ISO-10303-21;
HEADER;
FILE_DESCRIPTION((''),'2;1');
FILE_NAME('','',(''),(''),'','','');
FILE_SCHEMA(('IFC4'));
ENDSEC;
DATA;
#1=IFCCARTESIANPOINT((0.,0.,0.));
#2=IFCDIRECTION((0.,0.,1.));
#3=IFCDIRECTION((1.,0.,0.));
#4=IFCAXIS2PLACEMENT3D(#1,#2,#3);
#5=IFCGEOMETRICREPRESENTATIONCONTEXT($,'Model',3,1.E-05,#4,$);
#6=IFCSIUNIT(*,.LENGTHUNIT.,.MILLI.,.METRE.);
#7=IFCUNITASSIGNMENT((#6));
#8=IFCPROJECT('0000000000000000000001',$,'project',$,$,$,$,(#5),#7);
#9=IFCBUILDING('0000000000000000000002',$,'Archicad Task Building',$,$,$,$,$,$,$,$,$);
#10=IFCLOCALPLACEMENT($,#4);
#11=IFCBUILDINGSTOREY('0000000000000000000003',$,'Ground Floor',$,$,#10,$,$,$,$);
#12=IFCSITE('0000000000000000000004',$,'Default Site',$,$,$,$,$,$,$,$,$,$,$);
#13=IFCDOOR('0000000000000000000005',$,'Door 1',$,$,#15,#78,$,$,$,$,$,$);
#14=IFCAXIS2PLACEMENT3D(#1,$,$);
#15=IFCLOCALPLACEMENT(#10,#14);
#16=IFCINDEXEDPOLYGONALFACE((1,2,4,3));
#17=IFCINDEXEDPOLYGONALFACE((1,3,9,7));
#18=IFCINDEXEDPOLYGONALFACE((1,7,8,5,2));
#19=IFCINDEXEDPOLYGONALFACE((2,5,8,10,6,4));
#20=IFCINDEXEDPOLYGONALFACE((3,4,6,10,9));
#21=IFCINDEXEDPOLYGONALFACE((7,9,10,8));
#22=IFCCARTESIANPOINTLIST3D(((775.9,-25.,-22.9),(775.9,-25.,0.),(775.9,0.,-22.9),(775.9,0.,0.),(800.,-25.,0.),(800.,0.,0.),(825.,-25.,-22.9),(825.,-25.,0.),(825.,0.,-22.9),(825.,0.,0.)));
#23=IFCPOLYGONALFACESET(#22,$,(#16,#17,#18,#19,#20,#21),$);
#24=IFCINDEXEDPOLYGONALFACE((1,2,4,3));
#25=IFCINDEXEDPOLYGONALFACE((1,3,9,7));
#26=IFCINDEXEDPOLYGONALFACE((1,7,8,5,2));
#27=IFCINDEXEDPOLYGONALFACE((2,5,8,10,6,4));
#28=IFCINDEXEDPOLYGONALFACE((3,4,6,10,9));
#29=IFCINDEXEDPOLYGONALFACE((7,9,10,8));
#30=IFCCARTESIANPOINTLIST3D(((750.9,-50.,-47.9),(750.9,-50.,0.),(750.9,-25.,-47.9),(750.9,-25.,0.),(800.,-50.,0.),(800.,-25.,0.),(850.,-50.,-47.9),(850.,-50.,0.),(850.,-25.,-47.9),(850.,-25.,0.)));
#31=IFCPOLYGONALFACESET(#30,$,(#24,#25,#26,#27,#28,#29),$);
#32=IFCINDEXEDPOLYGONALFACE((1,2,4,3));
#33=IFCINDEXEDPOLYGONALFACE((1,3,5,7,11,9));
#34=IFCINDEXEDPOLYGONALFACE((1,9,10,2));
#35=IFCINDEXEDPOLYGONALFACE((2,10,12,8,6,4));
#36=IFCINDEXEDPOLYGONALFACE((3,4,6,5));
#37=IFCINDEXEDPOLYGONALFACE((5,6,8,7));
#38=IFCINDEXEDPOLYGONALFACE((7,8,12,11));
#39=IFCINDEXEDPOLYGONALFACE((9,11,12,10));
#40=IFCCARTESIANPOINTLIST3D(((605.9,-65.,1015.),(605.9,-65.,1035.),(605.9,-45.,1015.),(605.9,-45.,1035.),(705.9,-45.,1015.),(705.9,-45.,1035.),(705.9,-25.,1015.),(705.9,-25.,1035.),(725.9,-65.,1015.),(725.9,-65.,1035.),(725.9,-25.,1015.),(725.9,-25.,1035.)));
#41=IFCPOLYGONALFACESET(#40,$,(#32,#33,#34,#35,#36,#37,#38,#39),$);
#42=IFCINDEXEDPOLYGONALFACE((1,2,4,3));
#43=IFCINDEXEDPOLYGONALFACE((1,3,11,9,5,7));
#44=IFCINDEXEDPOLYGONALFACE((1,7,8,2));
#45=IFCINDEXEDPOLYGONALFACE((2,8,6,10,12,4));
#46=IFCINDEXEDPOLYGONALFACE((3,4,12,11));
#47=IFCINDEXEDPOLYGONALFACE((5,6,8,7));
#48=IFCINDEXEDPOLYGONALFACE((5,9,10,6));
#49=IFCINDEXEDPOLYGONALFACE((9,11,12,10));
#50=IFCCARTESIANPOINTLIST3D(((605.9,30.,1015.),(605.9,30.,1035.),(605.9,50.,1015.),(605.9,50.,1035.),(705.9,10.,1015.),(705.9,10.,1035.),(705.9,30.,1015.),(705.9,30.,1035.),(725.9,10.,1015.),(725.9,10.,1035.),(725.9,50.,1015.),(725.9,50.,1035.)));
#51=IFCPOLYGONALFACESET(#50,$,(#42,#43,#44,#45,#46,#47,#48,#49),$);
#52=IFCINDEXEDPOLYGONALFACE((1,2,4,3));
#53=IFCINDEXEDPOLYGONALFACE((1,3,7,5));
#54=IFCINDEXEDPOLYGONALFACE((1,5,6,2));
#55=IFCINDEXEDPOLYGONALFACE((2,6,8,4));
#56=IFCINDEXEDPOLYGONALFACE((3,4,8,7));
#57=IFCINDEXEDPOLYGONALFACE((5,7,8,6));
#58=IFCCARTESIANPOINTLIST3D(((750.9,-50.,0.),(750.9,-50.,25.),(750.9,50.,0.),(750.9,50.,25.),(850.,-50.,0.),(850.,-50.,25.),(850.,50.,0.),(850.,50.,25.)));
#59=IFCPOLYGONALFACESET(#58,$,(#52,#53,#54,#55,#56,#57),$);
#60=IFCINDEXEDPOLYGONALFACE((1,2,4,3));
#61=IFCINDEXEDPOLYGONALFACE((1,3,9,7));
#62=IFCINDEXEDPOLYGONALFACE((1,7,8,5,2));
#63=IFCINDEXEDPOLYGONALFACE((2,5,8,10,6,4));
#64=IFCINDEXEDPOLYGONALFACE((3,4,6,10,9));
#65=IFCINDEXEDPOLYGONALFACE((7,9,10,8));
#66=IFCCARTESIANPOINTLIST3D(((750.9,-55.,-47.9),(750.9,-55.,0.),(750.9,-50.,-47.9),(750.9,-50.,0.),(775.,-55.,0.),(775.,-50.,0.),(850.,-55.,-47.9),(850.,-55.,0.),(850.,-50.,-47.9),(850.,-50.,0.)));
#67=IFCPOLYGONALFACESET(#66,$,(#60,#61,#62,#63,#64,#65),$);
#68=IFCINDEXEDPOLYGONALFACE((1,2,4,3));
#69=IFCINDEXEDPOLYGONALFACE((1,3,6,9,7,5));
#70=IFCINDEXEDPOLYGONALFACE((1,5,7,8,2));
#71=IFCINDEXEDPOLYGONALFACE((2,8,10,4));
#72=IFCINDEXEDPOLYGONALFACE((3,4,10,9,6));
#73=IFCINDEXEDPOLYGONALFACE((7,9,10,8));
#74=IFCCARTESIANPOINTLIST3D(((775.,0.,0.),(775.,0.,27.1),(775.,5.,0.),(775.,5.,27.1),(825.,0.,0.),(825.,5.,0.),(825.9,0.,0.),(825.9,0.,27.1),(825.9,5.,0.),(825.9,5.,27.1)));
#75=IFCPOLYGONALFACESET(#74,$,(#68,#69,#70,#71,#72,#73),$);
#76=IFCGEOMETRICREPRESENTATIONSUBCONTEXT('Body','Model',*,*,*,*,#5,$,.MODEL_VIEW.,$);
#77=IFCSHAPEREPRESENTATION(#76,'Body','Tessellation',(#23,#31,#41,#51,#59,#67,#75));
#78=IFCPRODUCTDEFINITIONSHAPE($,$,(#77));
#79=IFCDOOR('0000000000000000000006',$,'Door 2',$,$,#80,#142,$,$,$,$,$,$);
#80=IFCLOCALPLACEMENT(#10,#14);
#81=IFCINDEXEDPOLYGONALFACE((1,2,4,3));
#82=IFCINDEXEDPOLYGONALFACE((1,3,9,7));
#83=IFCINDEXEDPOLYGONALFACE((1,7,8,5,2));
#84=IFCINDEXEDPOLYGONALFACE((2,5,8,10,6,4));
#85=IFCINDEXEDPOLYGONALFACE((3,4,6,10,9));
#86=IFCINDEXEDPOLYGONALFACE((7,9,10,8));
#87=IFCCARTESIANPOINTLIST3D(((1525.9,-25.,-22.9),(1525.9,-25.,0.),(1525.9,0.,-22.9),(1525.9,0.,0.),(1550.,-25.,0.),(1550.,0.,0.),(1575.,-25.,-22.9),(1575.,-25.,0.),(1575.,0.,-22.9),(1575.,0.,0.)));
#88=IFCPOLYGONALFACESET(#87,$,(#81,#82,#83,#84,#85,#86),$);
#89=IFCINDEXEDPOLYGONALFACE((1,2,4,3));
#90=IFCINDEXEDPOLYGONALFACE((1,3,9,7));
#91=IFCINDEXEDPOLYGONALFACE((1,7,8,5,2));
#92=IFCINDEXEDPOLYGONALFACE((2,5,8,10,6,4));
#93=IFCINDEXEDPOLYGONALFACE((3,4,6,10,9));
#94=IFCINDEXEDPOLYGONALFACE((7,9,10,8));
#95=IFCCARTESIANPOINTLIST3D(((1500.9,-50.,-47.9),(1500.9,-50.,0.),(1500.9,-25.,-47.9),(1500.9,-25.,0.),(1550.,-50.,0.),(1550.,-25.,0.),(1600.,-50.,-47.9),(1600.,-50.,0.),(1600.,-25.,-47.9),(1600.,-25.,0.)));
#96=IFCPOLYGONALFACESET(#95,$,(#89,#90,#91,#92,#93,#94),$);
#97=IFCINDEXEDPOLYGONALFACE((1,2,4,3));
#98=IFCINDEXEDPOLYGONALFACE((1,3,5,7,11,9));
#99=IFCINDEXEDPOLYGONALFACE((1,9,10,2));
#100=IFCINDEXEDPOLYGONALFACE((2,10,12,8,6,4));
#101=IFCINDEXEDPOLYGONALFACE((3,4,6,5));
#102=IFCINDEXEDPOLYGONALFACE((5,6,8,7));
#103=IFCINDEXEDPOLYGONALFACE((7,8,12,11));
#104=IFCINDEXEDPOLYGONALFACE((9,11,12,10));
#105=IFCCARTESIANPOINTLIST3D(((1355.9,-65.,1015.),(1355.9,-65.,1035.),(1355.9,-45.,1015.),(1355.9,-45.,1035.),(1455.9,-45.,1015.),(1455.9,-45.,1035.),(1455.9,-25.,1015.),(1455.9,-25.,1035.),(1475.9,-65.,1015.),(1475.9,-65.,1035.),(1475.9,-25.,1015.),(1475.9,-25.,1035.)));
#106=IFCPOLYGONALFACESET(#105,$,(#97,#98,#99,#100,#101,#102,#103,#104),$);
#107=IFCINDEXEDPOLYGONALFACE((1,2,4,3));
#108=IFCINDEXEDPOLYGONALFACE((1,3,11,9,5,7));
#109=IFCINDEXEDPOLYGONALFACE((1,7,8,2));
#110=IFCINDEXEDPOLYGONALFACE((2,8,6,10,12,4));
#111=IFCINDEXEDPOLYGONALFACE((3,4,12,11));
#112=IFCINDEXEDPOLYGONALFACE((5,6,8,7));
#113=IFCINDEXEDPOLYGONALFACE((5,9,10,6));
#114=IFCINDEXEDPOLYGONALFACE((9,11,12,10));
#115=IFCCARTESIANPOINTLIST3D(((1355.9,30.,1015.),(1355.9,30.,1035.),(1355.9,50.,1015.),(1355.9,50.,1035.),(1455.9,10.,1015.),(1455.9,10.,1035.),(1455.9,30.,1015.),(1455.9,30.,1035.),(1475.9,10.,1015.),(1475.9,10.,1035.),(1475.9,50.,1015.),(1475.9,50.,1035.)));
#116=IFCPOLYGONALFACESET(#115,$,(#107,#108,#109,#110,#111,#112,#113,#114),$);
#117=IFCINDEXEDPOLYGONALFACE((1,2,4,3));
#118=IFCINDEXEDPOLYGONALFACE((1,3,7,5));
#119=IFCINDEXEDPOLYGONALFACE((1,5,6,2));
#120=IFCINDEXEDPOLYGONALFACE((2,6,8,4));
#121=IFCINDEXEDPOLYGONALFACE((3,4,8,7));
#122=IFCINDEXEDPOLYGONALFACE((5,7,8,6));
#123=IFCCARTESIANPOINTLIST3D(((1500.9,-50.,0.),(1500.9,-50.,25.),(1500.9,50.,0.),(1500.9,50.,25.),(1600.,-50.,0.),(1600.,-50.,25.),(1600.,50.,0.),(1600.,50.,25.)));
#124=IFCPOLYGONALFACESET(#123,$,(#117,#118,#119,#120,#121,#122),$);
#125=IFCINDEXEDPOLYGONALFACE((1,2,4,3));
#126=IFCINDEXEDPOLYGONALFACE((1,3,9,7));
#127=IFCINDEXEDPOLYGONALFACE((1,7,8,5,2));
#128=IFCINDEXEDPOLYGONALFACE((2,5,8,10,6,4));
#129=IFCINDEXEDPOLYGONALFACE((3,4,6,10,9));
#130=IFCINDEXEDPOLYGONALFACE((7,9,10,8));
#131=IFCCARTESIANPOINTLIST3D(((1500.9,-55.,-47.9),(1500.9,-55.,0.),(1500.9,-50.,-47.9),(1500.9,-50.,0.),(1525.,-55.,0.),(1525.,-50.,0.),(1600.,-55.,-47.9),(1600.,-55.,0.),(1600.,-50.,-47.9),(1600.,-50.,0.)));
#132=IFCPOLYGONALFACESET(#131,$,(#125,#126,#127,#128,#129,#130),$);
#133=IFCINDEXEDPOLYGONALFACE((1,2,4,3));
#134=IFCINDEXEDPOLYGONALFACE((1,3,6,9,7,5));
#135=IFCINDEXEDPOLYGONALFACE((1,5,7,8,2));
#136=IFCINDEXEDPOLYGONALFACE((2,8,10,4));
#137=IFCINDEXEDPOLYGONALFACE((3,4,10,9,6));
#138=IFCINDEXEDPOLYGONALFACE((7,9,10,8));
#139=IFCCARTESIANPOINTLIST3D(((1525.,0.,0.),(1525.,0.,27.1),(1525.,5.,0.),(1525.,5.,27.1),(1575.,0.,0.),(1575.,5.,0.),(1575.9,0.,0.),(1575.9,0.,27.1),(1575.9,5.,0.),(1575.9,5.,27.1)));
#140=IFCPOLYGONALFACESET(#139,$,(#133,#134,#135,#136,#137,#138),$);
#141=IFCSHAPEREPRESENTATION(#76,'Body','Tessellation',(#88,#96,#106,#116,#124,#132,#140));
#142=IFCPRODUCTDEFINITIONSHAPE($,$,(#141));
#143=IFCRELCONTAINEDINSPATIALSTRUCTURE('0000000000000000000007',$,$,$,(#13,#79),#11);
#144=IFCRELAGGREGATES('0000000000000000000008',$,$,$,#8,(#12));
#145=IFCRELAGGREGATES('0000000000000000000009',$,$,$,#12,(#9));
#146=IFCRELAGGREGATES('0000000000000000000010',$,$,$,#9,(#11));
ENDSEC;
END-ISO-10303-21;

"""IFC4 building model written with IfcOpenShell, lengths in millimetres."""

from ifc_helpers import new_model, si_unit, frame, origin_with_axes, place, context, subcontext, project, spatial, line, indexed_curve, outline, extrude, element, save


model = new_model("IFC4")

# Units and contexts
model_context = context("Model", 3, precision=1e-05, world=origin_with_axes())
body_context = subcontext(model_context, "Body", "Model", "MODEL_VIEW")
ifc_project = project(units=[si_unit("LENGTHUNIT", "METRE", prefix="MILLI")], contexts=[model_context])

# Site, building, storey
site = spatial("IfcSite", under=ifc_project, Name="Default Site")
building = spatial("IfcBuilding", under=site, Name="Archicad Task Building")
storey_placement = place(None, origin_with_axes())
storey = spatial("IfcBuildingStorey", under=building, at=storey_placement, Name="Ground Floor")

# Doors
door_1_placement = place(storey_placement, frame((800.0, -50.0, 0.0), z_axis=(0.0, 0.0, 1.0), x_axis=(1.0, 0.0, 0.0)))
element("IfcDoor", 1, at=door_1_placement, inside=storey, Name="Door 1", context=body_context, shape_type="SweptSolid", body=[
    extrude(outline(indexed_curve([(0.0, 0.0), (0.0, 2.1), (0.9, 2.1), (0.9, 0.0), (-24.1, 0.0), (-24.1, -22.9), (25.0, -22.9), (25.0, 0.0)], segments=[line(1, 2, 3, 4, 5, 6, 7, 8, 1)])), frame((0.0, 25.0, 0.0), z_axis=(0.0, -1.0, 0.0), x_axis=(1.0, 0.0, 0.0)), (0.0, 0.0, -1.0), 25.0),
    extrude(outline(indexed_curve([(0.0, 0.0), (0.0, 2.1), (0.9, 2.1), (0.9, 0.0), (-49.1, 0.0), (-49.1, -47.9), (50.0, -47.9), (50.0, 0.0)], segments=[line(1, 2, 3, 4, 5, 6, 7, 8, 1)])), frame((0.0, 0.0, 0.0), z_axis=(0.0, -1.0, 0.0), x_axis=(1.0, 0.0, 0.0)), (0.0, 0.0, -1.0), 25.0),
    extrude(outline(indexed_curve([(0.0, 0.0), (-49.1, 0.0), (-49.1, 35.0), (0.0, 35.0)], segments=[line(1, 2, 3, 4, 1)])), frame((25.0, 25.0, 25.0), z_axis=(0.0, 0.0, 1.0), x_axis=(1.0, 0.0, 0.0)), (0.0, 0.0, 1.0), -47.9),
    extrude(outline(indexed_curve([(0.0, 0.0), (0.0, -40.0), (-120.0, -40.0), (-120.0, -20.0), (-20.0, -20.0), (-20.0, 0.0)], segments=[line(1, 2, 3, 4, 5, 6, 1)])), frame((-74.1, 25.0, 1015.0), z_axis=(0.0, 0.0, 1.0), x_axis=(1.0, 0.0, 0.0)), (0.0, 0.0, 1.0), 20.0),
    extrude(outline(indexed_curve([(0.0, 0.0), (0.0, 40.0), (-120.0, 40.0), (-120.0, 20.0), (-20.0, 20.0), (-20.0, 0.0)], segments=[line(1, 2, 3, 4, 5, 6, 1)])), frame((-74.1, 60.0, 1015.0), z_axis=(0.0, 0.0, 1.0), x_axis=(1.0, 0.0, 0.0)), (0.0, 0.0, 1.0), 20.0),
    extrude(outline(indexed_curve([(0.0, 0.0), (-99.1, 0.0), (-99.1, 100.0), (0.0, 100.0)], segments=[line(1, 2, 3, 4, 1)])), frame((50.0, 0.0, 0.0), z_axis=(0.0, 0.0, 1.0), x_axis=(1.0, 0.0, 0.0)), (0.0, 0.0, 1.0), 25.0),
    extrude(outline(indexed_curve([(0.0, 0.0), (0.0, 27.1), (50.9, 27.1), (50.9, 0.0), (-24.1, 0.0), (-24.1, -47.9), (75.0, -47.9), (75.0, 0.0)], segments=[line(1, 2, 3, 4, 5, 6, 7, 8, 1)])), frame((-25.0, -5.0, 0.0), z_axis=(0.0, -1.0, 0.0), x_axis=(1.0, 0.0, 0.0)), (0.0, 0.0, -1.0), 5.0),
    extrude(outline(indexed_curve([(0.0, 0.0), (0.0, 27.1), (50.9, 27.1), (50.9, 0.0), (0.9, 0.0), (0.9, -22.9), (50.0, -22.9), (50.0, 0.0)], segments=[line(1, 2, 3, 4, 5, 6, 7, 8, 1)])), frame((-25.0, 50.0, 0.0), z_axis=(0.0, -1.0, 0.0), x_axis=(1.0, 0.0, 0.0)), (0.0, 0.0, -1.0), 5.0),
])
door_2_placement = place(storey_placement, frame((1550.0, -50.0, 0.0), z_axis=(0.0, 0.0, 1.0), x_axis=(1.0, 0.0, 0.0)))
element("IfcDoor", 2, at=door_2_placement, inside=storey, Name="Door 2", context=body_context, shape_type="SweptSolid", body=[
    extrude(outline(indexed_curve([(0.0, 0.0), (0.0, 2.1), (0.9, 2.1), (0.9, 0.0), (-24.1, 0.0), (-24.1, -22.9), (25.0, -22.9), (25.0, 0.0)], segments=[line(1, 2, 3, 4, 5, 6, 7, 8, 1)])), frame((0.0, 25.0, 0.0), z_axis=(0.0, -1.0, 0.0), x_axis=(1.0, 0.0, 0.0)), (0.0, 0.0, -1.0), 25.0),
    extrude(outline(indexed_curve([(0.0, 0.0), (0.0, 2.1), (0.9, 2.1), (0.9, 0.0), (-49.1, 0.0), (-49.1, -47.9), (50.0, -47.9), (50.0, 0.0)], segments=[line(1, 2, 3, 4, 5, 6, 7, 8, 1)])), frame((0.0, 0.0, 0.0), z_axis=(0.0, -1.0, 0.0), x_axis=(1.0, 0.0, 0.0)), (0.0, 0.0, -1.0), 25.0),
    extrude(outline(indexed_curve([(0.0, 0.0), (-49.1, 0.0), (-49.1, 35.0), (0.0, 35.0)], segments=[line(1, 2, 3, 4, 1)])), frame((25.0, 25.0, 25.0), z_axis=(0.0, 0.0, 1.0), x_axis=(1.0, 0.0, 0.0)), (0.0, 0.0, 1.0), -47.9),
    extrude(outline(indexed_curve([(0.0, 0.0), (0.0, -40.0), (-120.0, -40.0), (-120.0, -20.0), (-20.0, -20.0), (-20.0, 0.0)], segments=[line(1, 2, 3, 4, 5, 6, 1)])), frame((-74.1, 25.0, 1015.0), z_axis=(0.0, 0.0, 1.0), x_axis=(1.0, 0.0, 0.0)), (0.0, 0.0, 1.0), 20.0),
    extrude(outline(indexed_curve([(0.0, 0.0), (0.0, 40.0), (-120.0, 40.0), (-120.0, 20.0), (-20.0, 20.0), (-20.0, 0.0)], segments=[line(1, 2, 3, 4, 5, 6, 1)])), frame((-74.1, 60.0, 1015.0), z_axis=(0.0, 0.0, 1.0), x_axis=(1.0, 0.0, 0.0)), (0.0, 0.0, 1.0), 20.0),
    extrude(outline(indexed_curve([(0.0, 0.0), (-99.1, 0.0), (-99.1, 100.0), (0.0, 100.0)], segments=[line(1, 2, 3, 4, 1)])), frame((50.0, 0.0, 0.0), z_axis=(0.0, 0.0, 1.0), x_axis=(1.0, 0.0, 0.0)), (0.0, 0.0, 1.0), 25.0),
    extrude(outline(indexed_curve([(0.0, 0.0), (0.0, 27.1), (50.9, 27.1), (50.9, 0.0), (-24.1, 0.0), (-24.1, -47.9), (75.0, -47.9), (75.0, 0.0)], segments=[line(1, 2, 3, 4, 5, 6, 7, 8, 1)])), frame((-25.0, -5.0, 0.0), z_axis=(0.0, -1.0, 0.0), x_axis=(1.0, 0.0, 0.0)), (0.0, 0.0, -1.0), 5.0),
    extrude(outline(indexed_curve([(0.0, 0.0), (0.0, 27.1), (50.9, 27.1), (50.9, 0.0), (0.9, 0.0), (0.9, -22.9), (50.0, -22.9), (50.0, 0.0)], segments=[line(1, 2, 3, 4, 5, 6, 7, 8, 1)])), frame((-25.0, 50.0, 0.0), z_axis=(0.0, -1.0, 0.0), x_axis=(1.0, 0.0, 0.0)), (0.0, 0.0, -1.0), 5.0),
])

save(model, "model.ifc")
